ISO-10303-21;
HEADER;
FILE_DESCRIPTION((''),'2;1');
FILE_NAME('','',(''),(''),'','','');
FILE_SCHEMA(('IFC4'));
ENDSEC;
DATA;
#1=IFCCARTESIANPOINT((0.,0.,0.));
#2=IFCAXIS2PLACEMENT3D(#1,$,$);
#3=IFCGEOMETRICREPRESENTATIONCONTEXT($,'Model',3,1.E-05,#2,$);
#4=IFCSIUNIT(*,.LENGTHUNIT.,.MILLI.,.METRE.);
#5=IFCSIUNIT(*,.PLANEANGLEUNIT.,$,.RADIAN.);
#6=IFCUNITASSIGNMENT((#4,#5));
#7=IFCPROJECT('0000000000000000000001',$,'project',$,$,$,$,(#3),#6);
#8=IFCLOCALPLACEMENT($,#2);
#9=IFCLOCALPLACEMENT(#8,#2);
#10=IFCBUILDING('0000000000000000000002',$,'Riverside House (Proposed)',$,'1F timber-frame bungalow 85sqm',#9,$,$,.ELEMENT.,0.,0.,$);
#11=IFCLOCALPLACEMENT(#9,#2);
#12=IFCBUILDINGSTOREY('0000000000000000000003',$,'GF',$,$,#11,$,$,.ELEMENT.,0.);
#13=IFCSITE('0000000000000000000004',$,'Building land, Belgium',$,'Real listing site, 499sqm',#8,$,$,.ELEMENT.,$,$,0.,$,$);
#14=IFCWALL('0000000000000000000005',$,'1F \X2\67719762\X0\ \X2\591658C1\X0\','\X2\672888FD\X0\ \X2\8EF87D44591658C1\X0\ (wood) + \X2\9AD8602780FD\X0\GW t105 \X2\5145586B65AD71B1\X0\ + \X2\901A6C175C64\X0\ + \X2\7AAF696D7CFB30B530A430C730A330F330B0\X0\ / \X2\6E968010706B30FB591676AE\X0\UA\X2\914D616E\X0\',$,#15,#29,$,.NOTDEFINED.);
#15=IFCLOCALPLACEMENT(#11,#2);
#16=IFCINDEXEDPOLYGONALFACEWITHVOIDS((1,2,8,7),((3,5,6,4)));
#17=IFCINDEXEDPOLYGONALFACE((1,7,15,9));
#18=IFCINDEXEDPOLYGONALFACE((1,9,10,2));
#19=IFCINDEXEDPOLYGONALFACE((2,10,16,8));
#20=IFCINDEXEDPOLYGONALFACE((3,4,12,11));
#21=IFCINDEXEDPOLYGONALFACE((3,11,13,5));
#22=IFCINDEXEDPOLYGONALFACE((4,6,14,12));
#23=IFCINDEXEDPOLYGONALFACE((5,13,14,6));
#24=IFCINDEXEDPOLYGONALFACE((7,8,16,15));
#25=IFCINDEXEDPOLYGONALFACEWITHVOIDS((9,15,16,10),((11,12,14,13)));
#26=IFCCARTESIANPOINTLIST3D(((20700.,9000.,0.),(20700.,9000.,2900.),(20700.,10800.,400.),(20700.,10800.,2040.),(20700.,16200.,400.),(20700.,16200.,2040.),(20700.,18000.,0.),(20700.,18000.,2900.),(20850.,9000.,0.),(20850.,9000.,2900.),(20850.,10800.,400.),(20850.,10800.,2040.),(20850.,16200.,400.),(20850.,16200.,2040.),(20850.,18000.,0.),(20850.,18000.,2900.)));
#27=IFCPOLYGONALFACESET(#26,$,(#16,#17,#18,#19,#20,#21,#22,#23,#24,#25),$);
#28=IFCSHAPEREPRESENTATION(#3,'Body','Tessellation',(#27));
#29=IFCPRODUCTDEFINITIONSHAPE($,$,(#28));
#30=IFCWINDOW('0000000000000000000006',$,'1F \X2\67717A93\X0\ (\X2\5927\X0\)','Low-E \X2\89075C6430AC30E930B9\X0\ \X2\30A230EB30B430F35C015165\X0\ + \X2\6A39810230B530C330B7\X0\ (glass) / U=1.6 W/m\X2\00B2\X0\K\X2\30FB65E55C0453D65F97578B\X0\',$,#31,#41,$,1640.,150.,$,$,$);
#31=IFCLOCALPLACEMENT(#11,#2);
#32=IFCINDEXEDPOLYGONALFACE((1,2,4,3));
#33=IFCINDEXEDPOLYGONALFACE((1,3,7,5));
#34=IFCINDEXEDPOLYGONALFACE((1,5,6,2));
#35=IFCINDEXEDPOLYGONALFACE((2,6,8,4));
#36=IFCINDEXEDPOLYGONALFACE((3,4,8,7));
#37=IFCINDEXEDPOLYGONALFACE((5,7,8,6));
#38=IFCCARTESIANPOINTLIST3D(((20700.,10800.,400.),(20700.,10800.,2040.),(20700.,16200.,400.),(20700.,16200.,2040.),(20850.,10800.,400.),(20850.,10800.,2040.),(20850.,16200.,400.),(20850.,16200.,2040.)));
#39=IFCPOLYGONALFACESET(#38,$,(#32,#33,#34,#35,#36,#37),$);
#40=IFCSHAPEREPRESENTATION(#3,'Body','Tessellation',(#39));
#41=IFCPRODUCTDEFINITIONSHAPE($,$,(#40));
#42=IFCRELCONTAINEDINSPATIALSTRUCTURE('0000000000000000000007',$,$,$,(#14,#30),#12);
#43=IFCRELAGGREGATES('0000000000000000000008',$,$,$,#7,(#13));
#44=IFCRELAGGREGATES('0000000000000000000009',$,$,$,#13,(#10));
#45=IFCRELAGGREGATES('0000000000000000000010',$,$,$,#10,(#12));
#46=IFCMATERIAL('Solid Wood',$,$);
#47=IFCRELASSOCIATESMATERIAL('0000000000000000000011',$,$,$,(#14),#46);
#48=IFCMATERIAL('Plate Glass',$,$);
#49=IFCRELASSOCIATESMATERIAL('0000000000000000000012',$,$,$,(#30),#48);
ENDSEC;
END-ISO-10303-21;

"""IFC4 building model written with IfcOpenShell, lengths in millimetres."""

from ifc_helpers import new_model, si_unit, frame, frame_2d, origin, place, context, project, spatial, rectangle, extrude, material, element, fill, save


model = new_model("IFC4")

# Units and contexts
model_context = context("Model", 3, precision=1e-05, world=origin())
ifc_project = project(units=[si_unit("LENGTHUNIT", "METRE", prefix="MILLI"), si_unit("PLANEANGLEUNIT", "RADIAN")], contexts=[model_context])

# Site, building, storey
site_placement = place(None, origin())
site = spatial("IfcSite", under=ifc_project, at=site_placement, Name="Building land, Belgium", ObjectType="Real listing site, 499sqm", CompositionType="ELEMENT", RefElevation=0.0)
building_placement = place(site_placement, origin())
building = spatial("IfcBuilding", under=site, at=building_placement, Name="Riverside House (Proposed)", ObjectType="1F timber-frame bungalow 85sqm", CompositionType="ELEMENT", ElevationOfRefHeight=0.0, ElevationOfTerrain=0.0)
storey_placement = place(building_placement, origin())
storey = spatial("IfcBuildingStorey", under=building, at=storey_placement, Name="GF", CompositionType="ELEMENT", Elevation=0.0)

# Shared definitions
ifc_material_1 = material(Name="Solid Wood")

# Wall, opening, window
wall_1_placement = place(storey_placement, frame((10350.0, 4500.0, 0.0)))
wall_1 = element("IfcWall", 1, at=wall_1_placement, inside=storey, material=ifc_material_1, Name="1F 東面 外壁", Description="木製 軸組外壁 (wood) + 高性能GW t105 充填断熱 + 通気層 + 窯業系サイディング / 準耐火・外皮UA配慮", PredefinedType="NOTDEFINED", context=model_context, shape_type="SweptSolid", body=[
    extrude(rectangle(XDim=150.0, YDim=9000.0, at=frame_2d((75.0, 4500.0))), frame((10350.0, 4500.0, 0.0)), (0.0, 0.0, 1.0), 2900.0),
])
opening_1_placement = place(storey_placement, frame((10350.0, 5400.0, 200.0)))
opening_1 = element("IfcOpeningElement", 2, at=opening_1_placement, cuts=wall_1, PredefinedType="NOTDEFINED", context=model_context, shape_type="SweptSolid", body=[
    extrude(rectangle(XDim=150.0, YDim=5400.0, at=frame_2d((75.0, 2700.0))), frame((10350.0, 5400.0, 200.0)), (0.0, 0.0, 1.0), 1640.0),
])
ifc_material_2 = material(Name="Plate Glass")
window_1_placement = place(storey_placement, frame((10350.0, 5400.0, 200.0)))
window_1 = element("IfcWindow", 3, at=window_1_placement, inside=storey, material=ifc_material_2, Name="1F 東窓 (大)", Description="Low-E 複層ガラス アルゴン封入 + 樹脂サッシ (glass) / U=1.6 W/m²K・日射取得型", OverallHeight=1640.0, OverallWidth=150.0, context=model_context, shape_type="SweptSolid", body=[
    extrude(rectangle(XDim=150.0, YDim=5400.0, at=frame_2d((75.0, 2700.0))), frame((10350.0, 5400.0, 200.0)), (0.0, 0.0, 1.0), 1640.0),
])
fill(opening_1, window_1)

save(model, "model.ifc")
